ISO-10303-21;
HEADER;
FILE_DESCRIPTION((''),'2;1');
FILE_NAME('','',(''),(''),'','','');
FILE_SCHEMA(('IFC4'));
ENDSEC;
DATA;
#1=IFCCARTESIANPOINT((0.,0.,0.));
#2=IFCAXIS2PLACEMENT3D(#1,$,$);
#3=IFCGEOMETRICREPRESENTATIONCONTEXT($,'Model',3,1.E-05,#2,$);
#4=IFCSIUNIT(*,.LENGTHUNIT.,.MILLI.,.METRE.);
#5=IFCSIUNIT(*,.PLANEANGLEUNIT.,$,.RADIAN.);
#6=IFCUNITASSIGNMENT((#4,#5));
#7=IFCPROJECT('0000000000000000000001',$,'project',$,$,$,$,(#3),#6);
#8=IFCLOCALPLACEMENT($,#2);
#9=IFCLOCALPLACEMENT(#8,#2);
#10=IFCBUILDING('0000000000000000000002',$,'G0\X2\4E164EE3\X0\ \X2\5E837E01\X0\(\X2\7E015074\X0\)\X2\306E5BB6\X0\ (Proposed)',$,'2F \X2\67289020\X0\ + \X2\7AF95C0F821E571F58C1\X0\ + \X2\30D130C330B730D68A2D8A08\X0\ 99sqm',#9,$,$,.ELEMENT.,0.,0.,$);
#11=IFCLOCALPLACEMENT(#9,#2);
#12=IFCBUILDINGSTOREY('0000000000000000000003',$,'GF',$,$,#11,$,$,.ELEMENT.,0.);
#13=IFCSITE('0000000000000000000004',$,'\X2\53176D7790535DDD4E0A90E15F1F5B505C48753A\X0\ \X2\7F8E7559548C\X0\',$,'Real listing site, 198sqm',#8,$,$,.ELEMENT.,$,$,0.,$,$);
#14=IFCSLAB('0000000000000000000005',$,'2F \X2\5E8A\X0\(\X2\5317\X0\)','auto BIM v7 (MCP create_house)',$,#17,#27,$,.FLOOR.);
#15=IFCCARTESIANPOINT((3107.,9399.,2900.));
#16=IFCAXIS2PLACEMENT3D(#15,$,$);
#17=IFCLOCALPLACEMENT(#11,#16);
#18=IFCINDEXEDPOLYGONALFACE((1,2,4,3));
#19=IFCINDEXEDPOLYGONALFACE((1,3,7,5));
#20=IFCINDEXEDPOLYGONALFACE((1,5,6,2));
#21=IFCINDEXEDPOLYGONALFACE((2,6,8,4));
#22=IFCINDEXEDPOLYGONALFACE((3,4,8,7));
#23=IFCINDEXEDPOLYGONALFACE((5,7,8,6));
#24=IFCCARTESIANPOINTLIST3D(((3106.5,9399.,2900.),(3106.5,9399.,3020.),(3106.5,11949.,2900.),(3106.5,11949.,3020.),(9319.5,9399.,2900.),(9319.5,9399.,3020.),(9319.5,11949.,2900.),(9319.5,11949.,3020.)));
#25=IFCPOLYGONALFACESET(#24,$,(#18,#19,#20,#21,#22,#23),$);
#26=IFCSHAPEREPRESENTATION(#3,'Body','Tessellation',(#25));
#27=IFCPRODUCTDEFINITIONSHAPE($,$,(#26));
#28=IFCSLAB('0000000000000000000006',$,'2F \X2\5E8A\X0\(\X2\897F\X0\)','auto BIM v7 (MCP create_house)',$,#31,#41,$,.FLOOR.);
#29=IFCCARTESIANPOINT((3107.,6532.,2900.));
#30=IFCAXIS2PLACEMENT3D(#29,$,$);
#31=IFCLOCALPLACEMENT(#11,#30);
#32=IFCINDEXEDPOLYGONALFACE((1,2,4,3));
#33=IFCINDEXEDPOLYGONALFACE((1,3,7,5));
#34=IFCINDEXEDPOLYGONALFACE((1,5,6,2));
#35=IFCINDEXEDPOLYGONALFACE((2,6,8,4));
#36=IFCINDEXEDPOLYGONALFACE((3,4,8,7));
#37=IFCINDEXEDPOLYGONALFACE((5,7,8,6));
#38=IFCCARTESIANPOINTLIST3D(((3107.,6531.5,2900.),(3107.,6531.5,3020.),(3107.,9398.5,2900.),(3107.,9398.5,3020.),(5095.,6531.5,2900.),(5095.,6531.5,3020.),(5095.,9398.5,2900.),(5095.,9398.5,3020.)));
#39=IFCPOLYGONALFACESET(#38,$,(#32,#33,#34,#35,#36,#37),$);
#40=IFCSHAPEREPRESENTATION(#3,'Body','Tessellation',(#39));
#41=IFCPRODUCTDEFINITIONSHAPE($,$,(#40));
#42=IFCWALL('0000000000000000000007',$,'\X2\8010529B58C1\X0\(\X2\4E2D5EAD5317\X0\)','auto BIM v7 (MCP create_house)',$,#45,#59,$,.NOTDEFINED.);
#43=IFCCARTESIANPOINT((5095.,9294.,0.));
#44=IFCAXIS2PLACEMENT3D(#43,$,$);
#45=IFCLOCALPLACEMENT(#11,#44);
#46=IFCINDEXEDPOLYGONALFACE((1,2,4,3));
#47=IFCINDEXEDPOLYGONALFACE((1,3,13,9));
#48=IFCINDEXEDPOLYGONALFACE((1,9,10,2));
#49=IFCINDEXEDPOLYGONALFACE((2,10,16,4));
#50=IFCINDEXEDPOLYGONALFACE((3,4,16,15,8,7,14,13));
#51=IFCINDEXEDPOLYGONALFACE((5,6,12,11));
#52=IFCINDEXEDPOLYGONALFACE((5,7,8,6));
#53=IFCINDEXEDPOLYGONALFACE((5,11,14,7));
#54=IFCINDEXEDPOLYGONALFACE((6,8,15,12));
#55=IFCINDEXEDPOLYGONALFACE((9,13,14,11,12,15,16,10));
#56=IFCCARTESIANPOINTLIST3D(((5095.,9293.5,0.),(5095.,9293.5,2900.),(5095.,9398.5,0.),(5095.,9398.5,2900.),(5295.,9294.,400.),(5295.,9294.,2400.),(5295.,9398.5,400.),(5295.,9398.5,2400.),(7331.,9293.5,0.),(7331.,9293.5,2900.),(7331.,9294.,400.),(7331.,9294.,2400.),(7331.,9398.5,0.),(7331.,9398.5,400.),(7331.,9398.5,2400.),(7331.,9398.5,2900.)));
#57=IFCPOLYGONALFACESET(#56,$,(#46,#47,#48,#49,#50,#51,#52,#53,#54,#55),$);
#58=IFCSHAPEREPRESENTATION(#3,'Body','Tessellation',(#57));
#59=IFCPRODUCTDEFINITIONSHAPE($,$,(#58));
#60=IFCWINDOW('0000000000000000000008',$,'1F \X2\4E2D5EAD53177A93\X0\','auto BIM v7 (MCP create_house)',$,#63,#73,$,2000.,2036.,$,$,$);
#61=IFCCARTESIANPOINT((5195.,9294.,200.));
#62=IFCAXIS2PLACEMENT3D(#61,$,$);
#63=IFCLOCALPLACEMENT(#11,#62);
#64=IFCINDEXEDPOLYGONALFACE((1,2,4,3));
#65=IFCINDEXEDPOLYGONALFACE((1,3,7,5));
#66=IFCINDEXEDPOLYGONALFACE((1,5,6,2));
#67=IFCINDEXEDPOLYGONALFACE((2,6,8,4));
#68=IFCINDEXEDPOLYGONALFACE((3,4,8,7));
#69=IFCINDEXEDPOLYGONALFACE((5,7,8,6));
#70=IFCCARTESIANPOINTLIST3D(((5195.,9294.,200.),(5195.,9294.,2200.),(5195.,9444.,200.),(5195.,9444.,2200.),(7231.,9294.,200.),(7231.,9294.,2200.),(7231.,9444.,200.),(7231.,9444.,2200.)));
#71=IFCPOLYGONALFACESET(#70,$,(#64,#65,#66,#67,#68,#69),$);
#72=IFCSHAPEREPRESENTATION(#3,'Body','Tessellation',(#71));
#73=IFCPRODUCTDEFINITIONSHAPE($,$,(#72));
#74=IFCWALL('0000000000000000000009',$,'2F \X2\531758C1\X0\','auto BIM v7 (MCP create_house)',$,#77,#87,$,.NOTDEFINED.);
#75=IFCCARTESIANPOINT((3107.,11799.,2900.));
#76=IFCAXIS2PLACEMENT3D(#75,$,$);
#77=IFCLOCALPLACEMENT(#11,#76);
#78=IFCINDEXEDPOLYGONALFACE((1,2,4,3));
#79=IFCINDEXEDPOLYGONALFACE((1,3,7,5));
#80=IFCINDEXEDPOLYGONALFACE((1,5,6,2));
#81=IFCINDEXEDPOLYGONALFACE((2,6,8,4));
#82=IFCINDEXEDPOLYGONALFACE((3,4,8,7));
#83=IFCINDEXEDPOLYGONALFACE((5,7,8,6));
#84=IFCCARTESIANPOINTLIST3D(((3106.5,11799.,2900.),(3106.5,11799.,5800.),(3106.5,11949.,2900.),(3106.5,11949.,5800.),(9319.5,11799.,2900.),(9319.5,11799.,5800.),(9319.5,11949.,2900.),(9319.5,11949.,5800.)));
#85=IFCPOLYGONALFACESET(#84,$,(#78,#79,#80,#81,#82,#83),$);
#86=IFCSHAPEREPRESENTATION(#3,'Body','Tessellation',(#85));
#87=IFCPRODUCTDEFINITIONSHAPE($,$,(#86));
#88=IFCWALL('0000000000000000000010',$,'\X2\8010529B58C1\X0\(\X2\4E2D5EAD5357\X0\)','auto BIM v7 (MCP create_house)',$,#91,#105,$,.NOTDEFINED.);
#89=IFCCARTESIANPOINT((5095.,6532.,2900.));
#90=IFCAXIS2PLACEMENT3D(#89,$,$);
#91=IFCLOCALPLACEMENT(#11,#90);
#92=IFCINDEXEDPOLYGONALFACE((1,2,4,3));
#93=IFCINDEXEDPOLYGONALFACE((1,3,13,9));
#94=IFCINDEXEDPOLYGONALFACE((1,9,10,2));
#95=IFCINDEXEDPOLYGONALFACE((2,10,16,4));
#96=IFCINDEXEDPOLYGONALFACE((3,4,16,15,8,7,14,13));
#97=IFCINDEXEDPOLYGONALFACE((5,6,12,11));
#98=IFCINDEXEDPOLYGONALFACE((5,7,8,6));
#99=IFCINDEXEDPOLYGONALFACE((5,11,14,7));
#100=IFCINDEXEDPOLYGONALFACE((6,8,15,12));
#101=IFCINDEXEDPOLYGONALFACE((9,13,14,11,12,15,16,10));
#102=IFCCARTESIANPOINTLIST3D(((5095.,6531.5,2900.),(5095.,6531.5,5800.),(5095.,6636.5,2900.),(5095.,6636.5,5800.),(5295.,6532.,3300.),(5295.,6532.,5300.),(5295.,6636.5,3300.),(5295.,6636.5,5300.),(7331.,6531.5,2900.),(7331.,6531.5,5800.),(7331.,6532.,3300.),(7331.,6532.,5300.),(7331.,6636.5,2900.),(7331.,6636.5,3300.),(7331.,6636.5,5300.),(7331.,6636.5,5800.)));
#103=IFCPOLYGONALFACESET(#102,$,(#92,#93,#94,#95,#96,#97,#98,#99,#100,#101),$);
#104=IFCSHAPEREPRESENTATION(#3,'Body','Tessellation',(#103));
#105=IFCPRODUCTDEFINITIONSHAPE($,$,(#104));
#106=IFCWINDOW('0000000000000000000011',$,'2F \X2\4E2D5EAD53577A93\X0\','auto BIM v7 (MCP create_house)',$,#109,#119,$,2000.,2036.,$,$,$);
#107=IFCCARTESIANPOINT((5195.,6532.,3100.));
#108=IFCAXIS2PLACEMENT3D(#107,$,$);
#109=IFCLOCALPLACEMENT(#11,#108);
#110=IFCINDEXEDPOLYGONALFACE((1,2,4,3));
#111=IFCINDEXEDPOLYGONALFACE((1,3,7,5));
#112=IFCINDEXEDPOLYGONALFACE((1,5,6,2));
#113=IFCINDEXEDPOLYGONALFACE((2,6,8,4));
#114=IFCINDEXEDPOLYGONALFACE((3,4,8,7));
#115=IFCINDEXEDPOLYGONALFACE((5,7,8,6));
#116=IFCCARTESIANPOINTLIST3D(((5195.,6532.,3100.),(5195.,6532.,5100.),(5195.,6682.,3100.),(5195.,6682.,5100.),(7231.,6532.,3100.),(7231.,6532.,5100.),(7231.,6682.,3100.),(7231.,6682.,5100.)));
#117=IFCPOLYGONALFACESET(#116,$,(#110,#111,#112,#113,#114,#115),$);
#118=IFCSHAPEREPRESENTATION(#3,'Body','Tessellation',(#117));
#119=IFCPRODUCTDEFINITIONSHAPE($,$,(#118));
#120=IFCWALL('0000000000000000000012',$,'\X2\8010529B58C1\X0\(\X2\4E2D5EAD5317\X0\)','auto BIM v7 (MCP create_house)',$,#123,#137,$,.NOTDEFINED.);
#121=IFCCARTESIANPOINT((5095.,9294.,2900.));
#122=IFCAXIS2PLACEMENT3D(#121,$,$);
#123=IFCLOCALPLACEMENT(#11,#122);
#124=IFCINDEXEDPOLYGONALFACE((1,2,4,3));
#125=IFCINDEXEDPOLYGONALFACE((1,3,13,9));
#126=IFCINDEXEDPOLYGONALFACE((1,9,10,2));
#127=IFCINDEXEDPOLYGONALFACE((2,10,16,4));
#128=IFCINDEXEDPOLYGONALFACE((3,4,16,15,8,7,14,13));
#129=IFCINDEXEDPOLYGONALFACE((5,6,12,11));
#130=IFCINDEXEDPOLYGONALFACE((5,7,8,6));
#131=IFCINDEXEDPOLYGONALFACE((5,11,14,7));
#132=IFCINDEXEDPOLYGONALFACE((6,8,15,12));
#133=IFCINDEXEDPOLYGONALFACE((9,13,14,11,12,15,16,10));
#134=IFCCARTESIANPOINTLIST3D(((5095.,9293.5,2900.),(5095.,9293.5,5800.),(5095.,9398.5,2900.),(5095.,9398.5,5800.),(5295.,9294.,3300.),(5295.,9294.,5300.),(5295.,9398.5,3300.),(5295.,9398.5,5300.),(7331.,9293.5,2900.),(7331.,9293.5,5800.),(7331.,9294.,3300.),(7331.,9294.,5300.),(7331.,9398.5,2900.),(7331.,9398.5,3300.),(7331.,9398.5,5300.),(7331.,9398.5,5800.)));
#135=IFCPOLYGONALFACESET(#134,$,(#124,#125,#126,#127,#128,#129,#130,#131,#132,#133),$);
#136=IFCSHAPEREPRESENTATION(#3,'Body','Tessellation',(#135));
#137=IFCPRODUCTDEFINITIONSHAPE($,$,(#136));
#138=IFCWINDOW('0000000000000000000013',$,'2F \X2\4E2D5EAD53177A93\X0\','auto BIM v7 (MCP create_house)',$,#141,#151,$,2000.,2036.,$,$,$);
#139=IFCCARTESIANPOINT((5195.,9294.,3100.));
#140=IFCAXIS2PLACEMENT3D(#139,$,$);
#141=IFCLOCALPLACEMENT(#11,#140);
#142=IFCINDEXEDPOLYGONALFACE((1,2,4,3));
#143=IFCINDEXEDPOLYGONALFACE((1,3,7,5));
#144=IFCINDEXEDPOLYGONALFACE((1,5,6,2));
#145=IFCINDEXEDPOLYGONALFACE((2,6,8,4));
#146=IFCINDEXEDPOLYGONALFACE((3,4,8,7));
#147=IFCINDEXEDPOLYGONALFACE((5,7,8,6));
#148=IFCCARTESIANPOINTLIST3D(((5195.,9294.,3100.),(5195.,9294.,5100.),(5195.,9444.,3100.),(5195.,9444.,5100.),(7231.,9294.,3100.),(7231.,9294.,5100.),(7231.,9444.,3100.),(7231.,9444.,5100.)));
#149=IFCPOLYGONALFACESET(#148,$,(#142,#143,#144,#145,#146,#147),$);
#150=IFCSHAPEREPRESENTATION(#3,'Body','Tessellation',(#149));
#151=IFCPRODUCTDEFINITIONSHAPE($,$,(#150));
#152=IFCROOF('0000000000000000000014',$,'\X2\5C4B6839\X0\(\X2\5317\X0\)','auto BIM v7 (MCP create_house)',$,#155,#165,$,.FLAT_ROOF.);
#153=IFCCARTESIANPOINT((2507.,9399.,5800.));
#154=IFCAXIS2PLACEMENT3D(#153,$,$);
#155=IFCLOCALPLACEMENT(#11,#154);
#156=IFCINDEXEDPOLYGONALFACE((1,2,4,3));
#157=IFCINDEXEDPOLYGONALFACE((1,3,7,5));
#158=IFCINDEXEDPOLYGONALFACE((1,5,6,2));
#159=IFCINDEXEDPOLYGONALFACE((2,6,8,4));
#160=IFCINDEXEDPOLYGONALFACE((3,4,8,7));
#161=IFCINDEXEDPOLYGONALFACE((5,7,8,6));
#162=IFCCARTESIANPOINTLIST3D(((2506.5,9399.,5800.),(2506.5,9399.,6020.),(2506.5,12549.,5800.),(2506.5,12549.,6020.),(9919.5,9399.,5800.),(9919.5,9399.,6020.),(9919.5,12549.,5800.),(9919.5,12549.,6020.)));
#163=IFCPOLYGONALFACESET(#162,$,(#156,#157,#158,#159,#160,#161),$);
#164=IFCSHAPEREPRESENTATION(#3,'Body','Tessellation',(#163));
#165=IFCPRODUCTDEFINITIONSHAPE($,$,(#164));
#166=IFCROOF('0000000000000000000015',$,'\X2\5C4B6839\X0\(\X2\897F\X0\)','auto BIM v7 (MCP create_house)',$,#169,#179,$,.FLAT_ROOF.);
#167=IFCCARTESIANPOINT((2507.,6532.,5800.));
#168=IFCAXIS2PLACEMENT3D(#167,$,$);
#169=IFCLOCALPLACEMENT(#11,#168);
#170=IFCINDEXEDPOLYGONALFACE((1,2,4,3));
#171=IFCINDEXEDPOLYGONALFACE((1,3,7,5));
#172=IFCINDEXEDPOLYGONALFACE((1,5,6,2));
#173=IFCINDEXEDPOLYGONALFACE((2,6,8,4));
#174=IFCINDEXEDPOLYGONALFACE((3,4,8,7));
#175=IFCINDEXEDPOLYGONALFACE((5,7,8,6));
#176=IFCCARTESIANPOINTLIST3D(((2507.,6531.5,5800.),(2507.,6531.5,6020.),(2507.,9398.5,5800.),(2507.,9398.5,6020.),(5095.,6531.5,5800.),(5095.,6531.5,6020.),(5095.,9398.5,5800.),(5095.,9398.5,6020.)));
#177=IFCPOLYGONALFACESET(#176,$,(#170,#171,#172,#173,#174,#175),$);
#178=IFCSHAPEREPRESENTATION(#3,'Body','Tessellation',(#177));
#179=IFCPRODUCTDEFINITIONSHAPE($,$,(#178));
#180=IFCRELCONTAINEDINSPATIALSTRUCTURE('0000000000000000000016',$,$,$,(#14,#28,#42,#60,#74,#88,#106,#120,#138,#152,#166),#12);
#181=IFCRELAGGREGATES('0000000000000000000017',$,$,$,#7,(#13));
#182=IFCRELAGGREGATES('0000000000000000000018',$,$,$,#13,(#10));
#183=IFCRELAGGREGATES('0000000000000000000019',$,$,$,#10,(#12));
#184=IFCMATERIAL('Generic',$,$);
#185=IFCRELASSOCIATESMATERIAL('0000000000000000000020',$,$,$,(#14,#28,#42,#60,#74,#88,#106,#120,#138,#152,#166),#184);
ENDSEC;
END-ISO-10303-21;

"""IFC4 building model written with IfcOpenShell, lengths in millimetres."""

from ifc_helpers import new_model, si_unit, frame, frame_2d, origin, place, context, project, spatial, rectangle, extrude, material, element, fill, save


model = new_model("IFC4")

# Units and contexts
model_context = context("Model", 3, precision=1e-05, world=origin())
ifc_project = project(units=[si_unit("LENGTHUNIT", "METRE", prefix="MILLI"), si_unit("PLANEANGLEUNIT", "RADIAN")], contexts=[model_context])

# Site, building, storey
site_placement = place(None, origin())
site = spatial("IfcSite", under=ifc_project, at=site_placement, Name="北海道川上郡弟子屈町 美留和", ObjectType="Real listing site, 198sqm", CompositionType="ELEMENT", RefElevation=0.0)
building_placement = place(site_placement, origin())
building = spatial("IfcBuilding", under=site, at=building_placement, Name="G0世代 広縁(縁側)の家 (Proposed)", ObjectType="2F 木造 + 竹小舞土壁 + パッシブ設計 99sqm", CompositionType="ELEMENT", ElevationOfRefHeight=0.0, ElevationOfTerrain=0.0)
storey_placement = place(building_placement, origin())
storey = spatial("IfcBuildingStorey", under=building, at=storey_placement, Name="GF", CompositionType="ELEMENT", Elevation=0.0)

# Slabs
ifc_material = material(Name="Generic")
slab_1_placement = place(storey_placement, frame((3107.0, 9399.0, 2900.0)))
element("IfcSlab", 1, at=slab_1_placement, inside=storey, material=ifc_material, Name="2F 床(北)", Description="auto BIM v7 (MCP create_house)", PredefinedType="FLOOR", context=model_context, shape_type="SweptSolid", body=[
    extrude(rectangle(XDim=6213.0, YDim=2550.0, at=frame_2d((3106.0, 1275.0))), frame((3107.0, 9399.0, 2900.0)), (0.0, 0.0, 1.0), 120.0),
])
slab_2_placement = place(storey_placement, frame((3107.0, 6532.0, 2900.0)))
element("IfcSlab", 2, at=slab_2_placement, inside=storey, material=ifc_material, Name="2F 床(西)", Description="auto BIM v7 (MCP create_house)", PredefinedType="FLOOR", context=model_context, shape_type="SweptSolid", body=[
    extrude(rectangle(XDim=1988.0, YDim=2867.0, at=frame_2d((994.0, 1433.0))), frame((3107.0, 6532.0, 2900.0)), (0.0, 0.0, 1.0), 120.0),
])

# Wall, opening, window
wall_1_placement = place(storey_placement, frame((5095.0, 9294.0, 0.0)))
wall_1 = element("IfcWall", 3, at=wall_1_placement, inside=storey, material=ifc_material, Name="耐力壁(中庭北)", Description="auto BIM v7 (MCP create_house)", PredefinedType="NOTDEFINED", context=model_context, shape_type="SweptSolid", body=[
    extrude(rectangle(XDim=2236.0, YDim=105.0, at=frame_2d((1118.0, 52.0))), frame((5095.0, 9294.0, 0.0)), (0.0, 0.0, 1.0), 2900.0),
])
opening_1_placement = place(storey_placement, frame((5195.0, 9294.0, 200.0)))
opening_1 = element("IfcOpeningElement", 4, at=opening_1_placement, cuts=wall_1, PredefinedType="NOTDEFINED", context=model_context, shape_type="SweptSolid", body=[
    extrude(rectangle(XDim=2036.0, YDim=150.0, at=frame_2d((1018.0, 75.0))), frame((5195.0, 9294.0, 200.0)), (0.0, 0.0, 1.0), 2000.0),
])
window_1_placement = place(storey_placement, frame((5195.0, 9294.0, 200.0)))
window_1 = element("IfcWindow", 5, at=window_1_placement, inside=storey, material=ifc_material, Name="1F 中庭北窓", Description="auto BIM v7 (MCP create_house)", OverallHeight=2000.0, OverallWidth=2036.0, context=model_context, shape_type="SweptSolid", body=[
    extrude(rectangle(XDim=2036.0, YDim=150.0, at=frame_2d((1018.0, 75.0))), frame((5195.0, 9294.0, 200.0)), (0.0, 0.0, 1.0), 2000.0),
])
fill(opening_1, window_1)

# Wall
wall_2_placement = place(storey_placement, frame((3107.0, 11799.0, 2900.0)))
element("IfcWall", 6, at=wall_2_placement, inside=storey, material=ifc_material, Name="2F 北壁", Description="auto BIM v7 (MCP create_house)", PredefinedType="NOTDEFINED", context=model_context, shape_type="SweptSolid", body=[
    extrude(rectangle(XDim=6213.0, YDim=150.0, at=frame_2d((3106.0, 75.0))), frame((3107.0, 11799.0, 2900.0)), (0.0, 0.0, 1.0), 2900.0),
])

# Walls, openings, windows
wall_3_placement = place(storey_placement, frame((5095.0, 6532.0, 2900.0)))
wall_3 = element("IfcWall", 7, at=wall_3_placement, inside=storey, material=ifc_material, Name="耐力壁(中庭南)", Description="auto BIM v7 (MCP create_house)", PredefinedType="NOTDEFINED", context=model_context, shape_type="SweptSolid", body=[
    extrude(rectangle(XDim=2236.0, YDim=105.0, at=frame_2d((1118.0, 52.0))), frame((5095.0, 6532.0, 2900.0)), (0.0, 0.0, 1.0), 2900.0),
])
opening_2_placement = place(storey_placement, frame((5195.0, 6532.0, 3100.0)))
opening_2 = element("IfcOpeningElement", 8, at=opening_2_placement, cuts=wall_3, PredefinedType="NOTDEFINED", context=model_context, shape_type="SweptSolid", body=[
    extrude(rectangle(XDim=2036.0, YDim=150.0, at=frame_2d((1018.0, 75.0))), frame((5195.0, 6532.0, 3100.0)), (0.0, 0.0, 1.0), 2000.0),
])
window_2_placement = place(storey_placement, frame((5195.0, 6532.0, 3100.0)))
window_2 = element("IfcWindow", 9, at=window_2_placement, inside=storey, material=ifc_material, Name="2F 中庭南窓", Description="auto BIM v7 (MCP create_house)", OverallHeight=2000.0, OverallWidth=2036.0, context=model_context, shape_type="SweptSolid", body=[
    extrude(rectangle(XDim=2036.0, YDim=150.0, at=frame_2d((1018.0, 75.0))), frame((5195.0, 6532.0, 3100.0)), (0.0, 0.0, 1.0), 2000.0),
])
fill(opening_2, window_2)
wall_4_placement = place(storey_placement, frame((5095.0, 9294.0, 2900.0)))
wall_4 = element("IfcWall", 10, at=wall_4_placement, inside=storey, material=ifc_material, Name="耐力壁(中庭北)", Description="auto BIM v7 (MCP create_house)", PredefinedType="NOTDEFINED", context=model_context, shape_type="SweptSolid", body=[
    extrude(rectangle(XDim=2236.0, YDim=105.0, at=frame_2d((1118.0, 52.0))), frame((5095.0, 9294.0, 2900.0)), (0.0, 0.0, 1.0), 2900.0),
])
opening_3_placement = place(storey_placement, frame((5195.0, 9294.0, 3100.0)))
opening_3 = element("IfcOpeningElement", 11, at=opening_3_placement, cuts=wall_4, PredefinedType="NOTDEFINED", context=model_context, shape_type="SweptSolid", body=[
    extrude(rectangle(XDim=2036.0, YDim=150.0, at=frame_2d((1018.0, 75.0))), frame((5195.0, 9294.0, 3100.0)), (0.0, 0.0, 1.0), 2000.0),
])
window_3_placement = place(storey_placement, frame((5195.0, 9294.0, 3100.0)))
window_3 = element("IfcWindow", 12, at=window_3_placement, inside=storey, material=ifc_material, Name="2F 中庭北窓", Description="auto BIM v7 (MCP create_house)", OverallHeight=2000.0, OverallWidth=2036.0, context=model_context, shape_type="SweptSolid", body=[
    extrude(rectangle(XDim=2036.0, YDim=150.0, at=frame_2d((1018.0, 75.0))), frame((5195.0, 9294.0, 3100.0)), (0.0, 0.0, 1.0), 2000.0),
])
fill(opening_3, window_3)

# Roofs
roof_1_placement = place(storey_placement, frame((2507.0, 9399.0, 5800.0)))
element("IfcRoof", 13, at=roof_1_placement, inside=storey, material=ifc_material, Name="屋根(北)", Description="auto BIM v7 (MCP create_house)", PredefinedType="FLAT_ROOF", context=model_context, shape_type="SweptSolid", body=[
    extrude(rectangle(XDim=7413.0, YDim=3150.0, at=frame_2d((3706.0, 1575.0))), frame((2507.0, 9399.0, 5800.0)), (0.0, 0.0, 1.0), 220.0),
])
roof_2_placement = place(storey_placement, frame((2507.0, 6532.0, 5800.0)))
element("IfcRoof", 14, at=roof_2_placement, inside=storey, material=ifc_material, Name="屋根(西)", Description="auto BIM v7 (MCP create_house)", PredefinedType="FLAT_ROOF", context=model_context, shape_type="SweptSolid", body=[
    extrude(rectangle(XDim=2588.0, YDim=2867.0, at=frame_2d((1294.0, 1433.0))), frame((2507.0, 6532.0, 5800.0)), (0.0, 0.0, 1.0), 220.0),
])

save(model, "model.ifc")
